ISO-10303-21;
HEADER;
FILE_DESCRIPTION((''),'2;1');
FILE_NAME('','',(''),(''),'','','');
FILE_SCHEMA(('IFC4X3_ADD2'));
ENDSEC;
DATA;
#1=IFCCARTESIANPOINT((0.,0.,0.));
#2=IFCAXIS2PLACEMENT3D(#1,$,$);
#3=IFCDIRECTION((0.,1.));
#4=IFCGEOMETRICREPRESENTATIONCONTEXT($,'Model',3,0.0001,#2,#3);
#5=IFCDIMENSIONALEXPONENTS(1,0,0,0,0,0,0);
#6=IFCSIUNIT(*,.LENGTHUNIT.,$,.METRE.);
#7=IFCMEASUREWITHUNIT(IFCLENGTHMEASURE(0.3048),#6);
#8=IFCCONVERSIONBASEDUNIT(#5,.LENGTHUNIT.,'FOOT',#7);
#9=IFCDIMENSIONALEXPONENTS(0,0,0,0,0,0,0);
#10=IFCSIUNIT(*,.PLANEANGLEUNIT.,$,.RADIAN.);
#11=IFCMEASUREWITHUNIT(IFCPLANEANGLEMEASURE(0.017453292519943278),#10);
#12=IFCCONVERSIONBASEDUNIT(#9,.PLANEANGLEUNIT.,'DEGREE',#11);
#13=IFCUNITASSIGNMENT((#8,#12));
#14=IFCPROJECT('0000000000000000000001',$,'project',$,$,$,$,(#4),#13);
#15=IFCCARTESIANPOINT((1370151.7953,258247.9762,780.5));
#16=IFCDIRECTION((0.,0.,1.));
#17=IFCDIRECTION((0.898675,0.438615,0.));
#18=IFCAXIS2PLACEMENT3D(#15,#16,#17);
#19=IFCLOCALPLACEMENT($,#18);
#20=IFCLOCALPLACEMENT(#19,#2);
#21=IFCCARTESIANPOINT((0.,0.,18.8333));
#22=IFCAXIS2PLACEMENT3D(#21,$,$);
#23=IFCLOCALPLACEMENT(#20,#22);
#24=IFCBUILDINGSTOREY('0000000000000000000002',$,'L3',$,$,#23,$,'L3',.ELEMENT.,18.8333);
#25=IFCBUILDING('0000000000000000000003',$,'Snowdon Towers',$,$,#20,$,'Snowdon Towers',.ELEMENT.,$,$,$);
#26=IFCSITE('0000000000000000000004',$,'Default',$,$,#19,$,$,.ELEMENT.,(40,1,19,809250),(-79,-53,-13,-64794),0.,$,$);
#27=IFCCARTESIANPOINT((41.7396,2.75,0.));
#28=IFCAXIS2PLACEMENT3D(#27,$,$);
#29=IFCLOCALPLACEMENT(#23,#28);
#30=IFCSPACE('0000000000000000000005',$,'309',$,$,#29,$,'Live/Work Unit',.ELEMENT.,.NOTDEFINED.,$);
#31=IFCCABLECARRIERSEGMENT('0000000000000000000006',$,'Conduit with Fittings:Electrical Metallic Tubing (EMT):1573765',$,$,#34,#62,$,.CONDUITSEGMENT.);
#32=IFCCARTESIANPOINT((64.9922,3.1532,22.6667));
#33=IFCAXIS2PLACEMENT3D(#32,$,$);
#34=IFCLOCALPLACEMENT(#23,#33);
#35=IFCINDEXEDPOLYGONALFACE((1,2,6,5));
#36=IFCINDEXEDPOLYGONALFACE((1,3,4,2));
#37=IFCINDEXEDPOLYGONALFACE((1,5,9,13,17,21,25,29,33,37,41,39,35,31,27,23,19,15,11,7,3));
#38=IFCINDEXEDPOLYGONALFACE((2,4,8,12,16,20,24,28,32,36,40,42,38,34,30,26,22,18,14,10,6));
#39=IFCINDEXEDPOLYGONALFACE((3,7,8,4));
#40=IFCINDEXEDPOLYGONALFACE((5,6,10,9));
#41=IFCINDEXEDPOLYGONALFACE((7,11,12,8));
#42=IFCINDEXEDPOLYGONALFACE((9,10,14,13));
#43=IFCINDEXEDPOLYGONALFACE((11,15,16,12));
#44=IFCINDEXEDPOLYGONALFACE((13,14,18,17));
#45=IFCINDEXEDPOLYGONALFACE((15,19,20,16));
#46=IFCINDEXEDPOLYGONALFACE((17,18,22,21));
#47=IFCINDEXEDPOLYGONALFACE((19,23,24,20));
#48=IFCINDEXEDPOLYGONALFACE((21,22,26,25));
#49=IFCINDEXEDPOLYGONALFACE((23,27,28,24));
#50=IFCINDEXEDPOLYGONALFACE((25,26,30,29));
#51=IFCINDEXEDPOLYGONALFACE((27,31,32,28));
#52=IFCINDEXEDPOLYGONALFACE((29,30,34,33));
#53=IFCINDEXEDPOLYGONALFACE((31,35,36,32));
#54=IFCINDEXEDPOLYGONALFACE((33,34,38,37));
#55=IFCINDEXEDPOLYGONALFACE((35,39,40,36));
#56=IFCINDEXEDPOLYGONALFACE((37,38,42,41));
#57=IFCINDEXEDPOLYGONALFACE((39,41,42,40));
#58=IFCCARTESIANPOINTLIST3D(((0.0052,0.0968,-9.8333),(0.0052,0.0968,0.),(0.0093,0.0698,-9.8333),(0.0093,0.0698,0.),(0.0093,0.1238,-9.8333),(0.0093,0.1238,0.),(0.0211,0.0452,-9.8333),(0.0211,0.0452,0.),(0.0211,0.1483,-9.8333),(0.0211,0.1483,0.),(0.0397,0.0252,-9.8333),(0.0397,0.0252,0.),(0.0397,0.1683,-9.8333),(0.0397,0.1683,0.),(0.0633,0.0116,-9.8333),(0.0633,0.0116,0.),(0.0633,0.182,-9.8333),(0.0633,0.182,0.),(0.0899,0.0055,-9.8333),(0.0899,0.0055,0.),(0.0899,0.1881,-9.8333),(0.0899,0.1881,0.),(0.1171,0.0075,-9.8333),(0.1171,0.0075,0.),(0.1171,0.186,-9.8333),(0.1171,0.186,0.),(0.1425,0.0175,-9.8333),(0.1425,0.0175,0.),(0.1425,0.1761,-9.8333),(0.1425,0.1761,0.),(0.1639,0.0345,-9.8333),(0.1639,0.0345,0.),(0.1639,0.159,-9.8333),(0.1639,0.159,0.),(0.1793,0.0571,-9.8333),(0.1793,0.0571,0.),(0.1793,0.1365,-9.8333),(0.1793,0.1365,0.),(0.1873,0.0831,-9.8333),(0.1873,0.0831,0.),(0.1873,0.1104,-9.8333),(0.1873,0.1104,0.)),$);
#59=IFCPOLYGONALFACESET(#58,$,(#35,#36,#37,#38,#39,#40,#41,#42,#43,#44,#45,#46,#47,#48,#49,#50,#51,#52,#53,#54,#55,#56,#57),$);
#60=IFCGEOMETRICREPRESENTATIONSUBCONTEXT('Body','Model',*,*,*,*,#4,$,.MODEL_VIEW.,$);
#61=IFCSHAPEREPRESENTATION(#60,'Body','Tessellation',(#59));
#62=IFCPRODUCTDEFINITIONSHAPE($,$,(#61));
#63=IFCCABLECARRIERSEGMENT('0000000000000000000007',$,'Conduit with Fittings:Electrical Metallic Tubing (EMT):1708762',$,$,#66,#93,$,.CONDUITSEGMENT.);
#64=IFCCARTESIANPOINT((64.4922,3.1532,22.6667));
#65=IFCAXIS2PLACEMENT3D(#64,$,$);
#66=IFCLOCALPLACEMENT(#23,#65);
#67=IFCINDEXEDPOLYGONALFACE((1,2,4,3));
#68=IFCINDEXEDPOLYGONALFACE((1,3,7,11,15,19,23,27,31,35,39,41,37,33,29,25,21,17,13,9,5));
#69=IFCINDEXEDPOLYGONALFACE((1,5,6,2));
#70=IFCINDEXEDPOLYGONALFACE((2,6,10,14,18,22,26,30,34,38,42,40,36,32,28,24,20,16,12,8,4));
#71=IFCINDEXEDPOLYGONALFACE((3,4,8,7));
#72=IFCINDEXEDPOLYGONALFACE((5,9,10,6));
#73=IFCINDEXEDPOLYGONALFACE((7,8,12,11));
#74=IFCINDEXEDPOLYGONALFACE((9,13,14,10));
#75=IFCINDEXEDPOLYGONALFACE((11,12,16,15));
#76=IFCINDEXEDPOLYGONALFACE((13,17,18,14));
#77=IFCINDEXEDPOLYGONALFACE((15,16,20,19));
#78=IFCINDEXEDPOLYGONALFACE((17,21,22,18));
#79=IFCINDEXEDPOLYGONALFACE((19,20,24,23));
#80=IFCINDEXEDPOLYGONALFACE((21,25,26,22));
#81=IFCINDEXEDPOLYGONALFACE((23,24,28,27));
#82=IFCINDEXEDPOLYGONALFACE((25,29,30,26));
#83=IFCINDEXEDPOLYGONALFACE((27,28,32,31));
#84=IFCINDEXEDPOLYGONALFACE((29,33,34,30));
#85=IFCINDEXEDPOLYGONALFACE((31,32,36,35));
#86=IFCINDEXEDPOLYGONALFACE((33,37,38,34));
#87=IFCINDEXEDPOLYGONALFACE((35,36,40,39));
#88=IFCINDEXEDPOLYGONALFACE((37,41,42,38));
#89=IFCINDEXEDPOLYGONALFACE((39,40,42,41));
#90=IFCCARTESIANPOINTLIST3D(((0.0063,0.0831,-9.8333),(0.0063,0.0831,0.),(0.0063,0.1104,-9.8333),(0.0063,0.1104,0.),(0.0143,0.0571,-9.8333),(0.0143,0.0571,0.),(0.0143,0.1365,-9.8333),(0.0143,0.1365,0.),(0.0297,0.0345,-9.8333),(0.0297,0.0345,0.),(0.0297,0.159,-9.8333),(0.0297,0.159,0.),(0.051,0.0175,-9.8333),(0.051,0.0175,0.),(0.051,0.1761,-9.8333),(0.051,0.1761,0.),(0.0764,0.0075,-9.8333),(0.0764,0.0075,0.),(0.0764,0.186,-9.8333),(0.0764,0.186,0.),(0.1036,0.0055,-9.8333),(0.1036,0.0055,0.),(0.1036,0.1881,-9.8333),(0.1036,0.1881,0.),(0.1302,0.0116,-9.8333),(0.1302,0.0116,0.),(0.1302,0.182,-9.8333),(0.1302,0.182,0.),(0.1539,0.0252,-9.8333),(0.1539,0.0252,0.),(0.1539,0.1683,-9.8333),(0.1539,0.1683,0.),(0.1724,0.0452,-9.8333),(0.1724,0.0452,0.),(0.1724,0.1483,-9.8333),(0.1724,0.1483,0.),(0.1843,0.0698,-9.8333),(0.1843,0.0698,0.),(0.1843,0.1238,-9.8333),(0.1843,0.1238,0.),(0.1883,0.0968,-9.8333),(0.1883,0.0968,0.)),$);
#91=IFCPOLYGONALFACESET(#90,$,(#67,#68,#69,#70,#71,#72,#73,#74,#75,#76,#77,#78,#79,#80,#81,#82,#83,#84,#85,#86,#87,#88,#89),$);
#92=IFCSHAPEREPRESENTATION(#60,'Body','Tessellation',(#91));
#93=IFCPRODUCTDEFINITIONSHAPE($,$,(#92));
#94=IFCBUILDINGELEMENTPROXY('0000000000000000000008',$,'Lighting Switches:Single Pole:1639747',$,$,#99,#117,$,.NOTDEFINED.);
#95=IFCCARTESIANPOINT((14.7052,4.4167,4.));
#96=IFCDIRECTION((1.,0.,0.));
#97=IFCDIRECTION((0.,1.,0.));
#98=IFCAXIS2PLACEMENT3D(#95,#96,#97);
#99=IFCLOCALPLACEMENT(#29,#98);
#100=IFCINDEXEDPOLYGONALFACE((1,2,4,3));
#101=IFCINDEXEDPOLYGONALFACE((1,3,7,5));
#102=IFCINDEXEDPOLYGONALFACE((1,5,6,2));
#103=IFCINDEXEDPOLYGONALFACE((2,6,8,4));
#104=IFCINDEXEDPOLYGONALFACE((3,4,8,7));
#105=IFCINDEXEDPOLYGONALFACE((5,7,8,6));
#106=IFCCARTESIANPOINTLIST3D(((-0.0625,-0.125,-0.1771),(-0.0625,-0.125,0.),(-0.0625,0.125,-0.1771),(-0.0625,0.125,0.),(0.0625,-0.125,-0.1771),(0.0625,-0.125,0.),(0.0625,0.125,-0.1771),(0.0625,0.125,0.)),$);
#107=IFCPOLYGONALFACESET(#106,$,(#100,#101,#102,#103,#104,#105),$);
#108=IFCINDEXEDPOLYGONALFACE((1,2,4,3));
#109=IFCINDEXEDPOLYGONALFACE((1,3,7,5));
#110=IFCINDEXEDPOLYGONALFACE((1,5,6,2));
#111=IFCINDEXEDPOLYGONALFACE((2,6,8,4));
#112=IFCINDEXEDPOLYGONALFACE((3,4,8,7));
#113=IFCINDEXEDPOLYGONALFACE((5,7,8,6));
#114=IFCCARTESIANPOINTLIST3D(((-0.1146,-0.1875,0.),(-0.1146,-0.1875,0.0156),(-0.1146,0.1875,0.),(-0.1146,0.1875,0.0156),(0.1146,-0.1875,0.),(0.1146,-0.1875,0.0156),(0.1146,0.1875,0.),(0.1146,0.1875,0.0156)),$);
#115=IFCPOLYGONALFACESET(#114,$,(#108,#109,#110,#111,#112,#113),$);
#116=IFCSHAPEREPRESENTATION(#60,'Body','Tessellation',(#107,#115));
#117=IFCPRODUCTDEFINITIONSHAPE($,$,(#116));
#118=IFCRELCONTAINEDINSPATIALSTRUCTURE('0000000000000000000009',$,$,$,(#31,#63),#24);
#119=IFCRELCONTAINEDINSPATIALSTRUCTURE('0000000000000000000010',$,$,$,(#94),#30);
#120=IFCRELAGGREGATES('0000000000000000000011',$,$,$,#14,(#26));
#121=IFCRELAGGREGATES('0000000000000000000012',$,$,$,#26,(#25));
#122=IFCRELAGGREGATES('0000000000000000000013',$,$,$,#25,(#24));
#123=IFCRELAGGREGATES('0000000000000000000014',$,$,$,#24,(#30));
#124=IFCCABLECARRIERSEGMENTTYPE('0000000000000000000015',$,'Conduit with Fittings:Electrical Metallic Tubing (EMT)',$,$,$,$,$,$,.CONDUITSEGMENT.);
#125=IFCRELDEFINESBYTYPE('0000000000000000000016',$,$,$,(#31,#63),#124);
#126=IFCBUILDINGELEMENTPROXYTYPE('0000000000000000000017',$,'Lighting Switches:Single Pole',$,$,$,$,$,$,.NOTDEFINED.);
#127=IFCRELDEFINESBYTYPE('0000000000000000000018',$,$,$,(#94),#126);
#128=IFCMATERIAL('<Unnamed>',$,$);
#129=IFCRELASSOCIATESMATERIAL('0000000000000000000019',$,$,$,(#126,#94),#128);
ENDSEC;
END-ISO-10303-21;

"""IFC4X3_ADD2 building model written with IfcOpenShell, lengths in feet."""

from ifc_helpers import new_model, entity, si_unit, converted_unit, direction, frame, frame_2d, origin, origin_2d_with_axis, place, context, subcontext, project, spatial, rectangle, circle, extrude, source, transform, mapped, material, type_object, type_shapes, element, save


model = new_model("IFC4X3_ADD2")

# Units and contexts
model_context = context("Model", 3, precision=0.0001, world=origin(), true_north=direction((0.0, 1.0)))
body_context = subcontext(model_context, "Body", "Model", "MODEL_VIEW")
ifc_project = project(units=[converted_unit("LENGTHUNIT", "FOOT", entity("IfcLengthMeasure", 0.3048), si_unit("LENGTHUNIT", "METRE"), dimensions=[1, 0, 0, 0, 0, 0, 0]), converted_unit("PLANEANGLEUNIT", "DEGREE", entity("IfcPlaneAngleMeasure", 0.017453292519943278), si_unit("PLANEANGLEUNIT", "RADIAN"), dimensions=[0, 0, 0, 0, 0, 0, 0])], contexts=[model_context])

# Site, building, storey
site_placement = place(None, frame((1370151.7953, 258247.9762, 780.5), z_axis=(0.0, 0.0, 1.0), x_axis=(0.898675, 0.438615, 0.0)))
site = spatial("IfcSite", under=ifc_project, at=site_placement, Name="Default", CompositionType="ELEMENT", RefLatitude=(40, 1, 19, 809250), RefLongitude=(-79, -53, -13, -64794), RefElevation=0.0)
building_placement = place(site_placement, origin())
building = spatial("IfcBuilding", under=site, at=building_placement, Name="Snowdon Towers", LongName="Snowdon Towers", CompositionType="ELEMENT")
storey_placement = place(building_placement, frame((0.0, 0.0, 18.8333)))
storey = spatial("IfcBuildingStorey", under=building, at=storey_placement, Name="L3", LongName="L3", CompositionType="ELEMENT", Elevation=18.8333)

# Cable carrier segments
cable_carrier_segment_type = type_object("IfcCableCarrierSegmentType", Name="Conduit with Fittings:Electrical Metallic Tubing (EMT)", PredefinedType="CONDUITSEGMENT")
cable_carrier_segment_1_placement = place(storey_placement, frame((64.9922, 3.1532, 22.6667)))
element("IfcCableCarrierSegment", 1, at=cable_carrier_segment_1_placement, inside=storey, type_object=cable_carrier_segment_type, Name="Conduit with Fittings:Electrical Metallic Tubing (EMT):1573765", PredefinedType="CONDUITSEGMENT", context=body_context, shape_type="SweptSolid", body=[
    extrude(circle(Radius=0.0915, at=frame_2d((0.0, 0.0), x_axis=(1.0, 0.0))), frame((0.0968, 0.0968, -9.8333), z_axis=(0.0, 0.0, 1.0), x_axis=(-1.0, 0.0, 0.0)), (0.0, 0.0, 1.0), 9.8333),
])
cable_carrier_segment_2_placement = place(storey_placement, frame((64.4922, 3.1532, 22.6667)))
element("IfcCableCarrierSegment", 2, at=cable_carrier_segment_2_placement, inside=storey, type_object=cable_carrier_segment_type, Name="Conduit with Fittings:Electrical Metallic Tubing (EMT):1708762", PredefinedType="CONDUITSEGMENT", context=body_context, shape_type="SweptSolid", body=[
    extrude(circle(Radius=0.0915, at=frame_2d((0.0, 0.0), x_axis=(1.0, 0.0))), frame((0.0968, 0.0968, -9.8333)), (0.0, 0.0, 1.0), 9.8333),
])

# Shared definitions
space_placement = place(storey_placement, frame((41.7396, 2.75, 0.0)))
space = spatial("IfcSpace", under=storey, at=space_placement, Name="309", LongName="Live/Work Unit", CompositionType="ELEMENT", PredefinedType="NOTDEFINED")

# Building element proxy
ifc_material = material(Name="<Unnamed>")
building_element_proxy_type_1 = type_object("IfcBuildingElementProxyType", Name="Lighting Switches:Single Pole", PredefinedType="NOTDEFINED", material=ifc_material)
shared_shape_1 = source(origin(), body_context, "Body", "SweptSolid", [
    extrude(rectangle(XDim=0.125, YDim=0.25, at=origin_2d_with_axis()), frame((0.0, 0.0, -0.1771), z_axis=(0.0, 0.0, 1.0), x_axis=(-1.0, 0.0, 0.0)), (0.0, 0.0, 1.0), 0.1771),
    extrude(rectangle(XDim=0.2292, YDim=0.375, at=frame_2d((0.0, 0.0), x_axis=(1.0, 0.0))), frame((0.0, 0.0, 0.0), z_axis=(0.0, 0.0, 1.0), x_axis=(-1.0, 0.0, 0.0)), (0.0, 0.0, 1.0), 0.0156),
])
type_shapes(building_element_proxy_type_1, [shared_shape_1])
proxy_1_placement = place(space_placement, frame((14.7052, 4.4167, 4.0), z_axis=(1.0, 0.0, 0.0), x_axis=(0.0, 1.0, 0.0)))
element("IfcBuildingElementProxy", 3, at=proxy_1_placement, inside=space, type_object=building_element_proxy_type_1, material=ifc_material, Name="Lighting Switches:Single Pole:1639747", PredefinedType="NOTDEFINED", context=body_context, shape_type="MappedRepresentation", body=[
    mapped(shared_shape_1, transform((0.0, 0.0, 0.0), scale=1.0)),
])

save(model, "model.ifc")
